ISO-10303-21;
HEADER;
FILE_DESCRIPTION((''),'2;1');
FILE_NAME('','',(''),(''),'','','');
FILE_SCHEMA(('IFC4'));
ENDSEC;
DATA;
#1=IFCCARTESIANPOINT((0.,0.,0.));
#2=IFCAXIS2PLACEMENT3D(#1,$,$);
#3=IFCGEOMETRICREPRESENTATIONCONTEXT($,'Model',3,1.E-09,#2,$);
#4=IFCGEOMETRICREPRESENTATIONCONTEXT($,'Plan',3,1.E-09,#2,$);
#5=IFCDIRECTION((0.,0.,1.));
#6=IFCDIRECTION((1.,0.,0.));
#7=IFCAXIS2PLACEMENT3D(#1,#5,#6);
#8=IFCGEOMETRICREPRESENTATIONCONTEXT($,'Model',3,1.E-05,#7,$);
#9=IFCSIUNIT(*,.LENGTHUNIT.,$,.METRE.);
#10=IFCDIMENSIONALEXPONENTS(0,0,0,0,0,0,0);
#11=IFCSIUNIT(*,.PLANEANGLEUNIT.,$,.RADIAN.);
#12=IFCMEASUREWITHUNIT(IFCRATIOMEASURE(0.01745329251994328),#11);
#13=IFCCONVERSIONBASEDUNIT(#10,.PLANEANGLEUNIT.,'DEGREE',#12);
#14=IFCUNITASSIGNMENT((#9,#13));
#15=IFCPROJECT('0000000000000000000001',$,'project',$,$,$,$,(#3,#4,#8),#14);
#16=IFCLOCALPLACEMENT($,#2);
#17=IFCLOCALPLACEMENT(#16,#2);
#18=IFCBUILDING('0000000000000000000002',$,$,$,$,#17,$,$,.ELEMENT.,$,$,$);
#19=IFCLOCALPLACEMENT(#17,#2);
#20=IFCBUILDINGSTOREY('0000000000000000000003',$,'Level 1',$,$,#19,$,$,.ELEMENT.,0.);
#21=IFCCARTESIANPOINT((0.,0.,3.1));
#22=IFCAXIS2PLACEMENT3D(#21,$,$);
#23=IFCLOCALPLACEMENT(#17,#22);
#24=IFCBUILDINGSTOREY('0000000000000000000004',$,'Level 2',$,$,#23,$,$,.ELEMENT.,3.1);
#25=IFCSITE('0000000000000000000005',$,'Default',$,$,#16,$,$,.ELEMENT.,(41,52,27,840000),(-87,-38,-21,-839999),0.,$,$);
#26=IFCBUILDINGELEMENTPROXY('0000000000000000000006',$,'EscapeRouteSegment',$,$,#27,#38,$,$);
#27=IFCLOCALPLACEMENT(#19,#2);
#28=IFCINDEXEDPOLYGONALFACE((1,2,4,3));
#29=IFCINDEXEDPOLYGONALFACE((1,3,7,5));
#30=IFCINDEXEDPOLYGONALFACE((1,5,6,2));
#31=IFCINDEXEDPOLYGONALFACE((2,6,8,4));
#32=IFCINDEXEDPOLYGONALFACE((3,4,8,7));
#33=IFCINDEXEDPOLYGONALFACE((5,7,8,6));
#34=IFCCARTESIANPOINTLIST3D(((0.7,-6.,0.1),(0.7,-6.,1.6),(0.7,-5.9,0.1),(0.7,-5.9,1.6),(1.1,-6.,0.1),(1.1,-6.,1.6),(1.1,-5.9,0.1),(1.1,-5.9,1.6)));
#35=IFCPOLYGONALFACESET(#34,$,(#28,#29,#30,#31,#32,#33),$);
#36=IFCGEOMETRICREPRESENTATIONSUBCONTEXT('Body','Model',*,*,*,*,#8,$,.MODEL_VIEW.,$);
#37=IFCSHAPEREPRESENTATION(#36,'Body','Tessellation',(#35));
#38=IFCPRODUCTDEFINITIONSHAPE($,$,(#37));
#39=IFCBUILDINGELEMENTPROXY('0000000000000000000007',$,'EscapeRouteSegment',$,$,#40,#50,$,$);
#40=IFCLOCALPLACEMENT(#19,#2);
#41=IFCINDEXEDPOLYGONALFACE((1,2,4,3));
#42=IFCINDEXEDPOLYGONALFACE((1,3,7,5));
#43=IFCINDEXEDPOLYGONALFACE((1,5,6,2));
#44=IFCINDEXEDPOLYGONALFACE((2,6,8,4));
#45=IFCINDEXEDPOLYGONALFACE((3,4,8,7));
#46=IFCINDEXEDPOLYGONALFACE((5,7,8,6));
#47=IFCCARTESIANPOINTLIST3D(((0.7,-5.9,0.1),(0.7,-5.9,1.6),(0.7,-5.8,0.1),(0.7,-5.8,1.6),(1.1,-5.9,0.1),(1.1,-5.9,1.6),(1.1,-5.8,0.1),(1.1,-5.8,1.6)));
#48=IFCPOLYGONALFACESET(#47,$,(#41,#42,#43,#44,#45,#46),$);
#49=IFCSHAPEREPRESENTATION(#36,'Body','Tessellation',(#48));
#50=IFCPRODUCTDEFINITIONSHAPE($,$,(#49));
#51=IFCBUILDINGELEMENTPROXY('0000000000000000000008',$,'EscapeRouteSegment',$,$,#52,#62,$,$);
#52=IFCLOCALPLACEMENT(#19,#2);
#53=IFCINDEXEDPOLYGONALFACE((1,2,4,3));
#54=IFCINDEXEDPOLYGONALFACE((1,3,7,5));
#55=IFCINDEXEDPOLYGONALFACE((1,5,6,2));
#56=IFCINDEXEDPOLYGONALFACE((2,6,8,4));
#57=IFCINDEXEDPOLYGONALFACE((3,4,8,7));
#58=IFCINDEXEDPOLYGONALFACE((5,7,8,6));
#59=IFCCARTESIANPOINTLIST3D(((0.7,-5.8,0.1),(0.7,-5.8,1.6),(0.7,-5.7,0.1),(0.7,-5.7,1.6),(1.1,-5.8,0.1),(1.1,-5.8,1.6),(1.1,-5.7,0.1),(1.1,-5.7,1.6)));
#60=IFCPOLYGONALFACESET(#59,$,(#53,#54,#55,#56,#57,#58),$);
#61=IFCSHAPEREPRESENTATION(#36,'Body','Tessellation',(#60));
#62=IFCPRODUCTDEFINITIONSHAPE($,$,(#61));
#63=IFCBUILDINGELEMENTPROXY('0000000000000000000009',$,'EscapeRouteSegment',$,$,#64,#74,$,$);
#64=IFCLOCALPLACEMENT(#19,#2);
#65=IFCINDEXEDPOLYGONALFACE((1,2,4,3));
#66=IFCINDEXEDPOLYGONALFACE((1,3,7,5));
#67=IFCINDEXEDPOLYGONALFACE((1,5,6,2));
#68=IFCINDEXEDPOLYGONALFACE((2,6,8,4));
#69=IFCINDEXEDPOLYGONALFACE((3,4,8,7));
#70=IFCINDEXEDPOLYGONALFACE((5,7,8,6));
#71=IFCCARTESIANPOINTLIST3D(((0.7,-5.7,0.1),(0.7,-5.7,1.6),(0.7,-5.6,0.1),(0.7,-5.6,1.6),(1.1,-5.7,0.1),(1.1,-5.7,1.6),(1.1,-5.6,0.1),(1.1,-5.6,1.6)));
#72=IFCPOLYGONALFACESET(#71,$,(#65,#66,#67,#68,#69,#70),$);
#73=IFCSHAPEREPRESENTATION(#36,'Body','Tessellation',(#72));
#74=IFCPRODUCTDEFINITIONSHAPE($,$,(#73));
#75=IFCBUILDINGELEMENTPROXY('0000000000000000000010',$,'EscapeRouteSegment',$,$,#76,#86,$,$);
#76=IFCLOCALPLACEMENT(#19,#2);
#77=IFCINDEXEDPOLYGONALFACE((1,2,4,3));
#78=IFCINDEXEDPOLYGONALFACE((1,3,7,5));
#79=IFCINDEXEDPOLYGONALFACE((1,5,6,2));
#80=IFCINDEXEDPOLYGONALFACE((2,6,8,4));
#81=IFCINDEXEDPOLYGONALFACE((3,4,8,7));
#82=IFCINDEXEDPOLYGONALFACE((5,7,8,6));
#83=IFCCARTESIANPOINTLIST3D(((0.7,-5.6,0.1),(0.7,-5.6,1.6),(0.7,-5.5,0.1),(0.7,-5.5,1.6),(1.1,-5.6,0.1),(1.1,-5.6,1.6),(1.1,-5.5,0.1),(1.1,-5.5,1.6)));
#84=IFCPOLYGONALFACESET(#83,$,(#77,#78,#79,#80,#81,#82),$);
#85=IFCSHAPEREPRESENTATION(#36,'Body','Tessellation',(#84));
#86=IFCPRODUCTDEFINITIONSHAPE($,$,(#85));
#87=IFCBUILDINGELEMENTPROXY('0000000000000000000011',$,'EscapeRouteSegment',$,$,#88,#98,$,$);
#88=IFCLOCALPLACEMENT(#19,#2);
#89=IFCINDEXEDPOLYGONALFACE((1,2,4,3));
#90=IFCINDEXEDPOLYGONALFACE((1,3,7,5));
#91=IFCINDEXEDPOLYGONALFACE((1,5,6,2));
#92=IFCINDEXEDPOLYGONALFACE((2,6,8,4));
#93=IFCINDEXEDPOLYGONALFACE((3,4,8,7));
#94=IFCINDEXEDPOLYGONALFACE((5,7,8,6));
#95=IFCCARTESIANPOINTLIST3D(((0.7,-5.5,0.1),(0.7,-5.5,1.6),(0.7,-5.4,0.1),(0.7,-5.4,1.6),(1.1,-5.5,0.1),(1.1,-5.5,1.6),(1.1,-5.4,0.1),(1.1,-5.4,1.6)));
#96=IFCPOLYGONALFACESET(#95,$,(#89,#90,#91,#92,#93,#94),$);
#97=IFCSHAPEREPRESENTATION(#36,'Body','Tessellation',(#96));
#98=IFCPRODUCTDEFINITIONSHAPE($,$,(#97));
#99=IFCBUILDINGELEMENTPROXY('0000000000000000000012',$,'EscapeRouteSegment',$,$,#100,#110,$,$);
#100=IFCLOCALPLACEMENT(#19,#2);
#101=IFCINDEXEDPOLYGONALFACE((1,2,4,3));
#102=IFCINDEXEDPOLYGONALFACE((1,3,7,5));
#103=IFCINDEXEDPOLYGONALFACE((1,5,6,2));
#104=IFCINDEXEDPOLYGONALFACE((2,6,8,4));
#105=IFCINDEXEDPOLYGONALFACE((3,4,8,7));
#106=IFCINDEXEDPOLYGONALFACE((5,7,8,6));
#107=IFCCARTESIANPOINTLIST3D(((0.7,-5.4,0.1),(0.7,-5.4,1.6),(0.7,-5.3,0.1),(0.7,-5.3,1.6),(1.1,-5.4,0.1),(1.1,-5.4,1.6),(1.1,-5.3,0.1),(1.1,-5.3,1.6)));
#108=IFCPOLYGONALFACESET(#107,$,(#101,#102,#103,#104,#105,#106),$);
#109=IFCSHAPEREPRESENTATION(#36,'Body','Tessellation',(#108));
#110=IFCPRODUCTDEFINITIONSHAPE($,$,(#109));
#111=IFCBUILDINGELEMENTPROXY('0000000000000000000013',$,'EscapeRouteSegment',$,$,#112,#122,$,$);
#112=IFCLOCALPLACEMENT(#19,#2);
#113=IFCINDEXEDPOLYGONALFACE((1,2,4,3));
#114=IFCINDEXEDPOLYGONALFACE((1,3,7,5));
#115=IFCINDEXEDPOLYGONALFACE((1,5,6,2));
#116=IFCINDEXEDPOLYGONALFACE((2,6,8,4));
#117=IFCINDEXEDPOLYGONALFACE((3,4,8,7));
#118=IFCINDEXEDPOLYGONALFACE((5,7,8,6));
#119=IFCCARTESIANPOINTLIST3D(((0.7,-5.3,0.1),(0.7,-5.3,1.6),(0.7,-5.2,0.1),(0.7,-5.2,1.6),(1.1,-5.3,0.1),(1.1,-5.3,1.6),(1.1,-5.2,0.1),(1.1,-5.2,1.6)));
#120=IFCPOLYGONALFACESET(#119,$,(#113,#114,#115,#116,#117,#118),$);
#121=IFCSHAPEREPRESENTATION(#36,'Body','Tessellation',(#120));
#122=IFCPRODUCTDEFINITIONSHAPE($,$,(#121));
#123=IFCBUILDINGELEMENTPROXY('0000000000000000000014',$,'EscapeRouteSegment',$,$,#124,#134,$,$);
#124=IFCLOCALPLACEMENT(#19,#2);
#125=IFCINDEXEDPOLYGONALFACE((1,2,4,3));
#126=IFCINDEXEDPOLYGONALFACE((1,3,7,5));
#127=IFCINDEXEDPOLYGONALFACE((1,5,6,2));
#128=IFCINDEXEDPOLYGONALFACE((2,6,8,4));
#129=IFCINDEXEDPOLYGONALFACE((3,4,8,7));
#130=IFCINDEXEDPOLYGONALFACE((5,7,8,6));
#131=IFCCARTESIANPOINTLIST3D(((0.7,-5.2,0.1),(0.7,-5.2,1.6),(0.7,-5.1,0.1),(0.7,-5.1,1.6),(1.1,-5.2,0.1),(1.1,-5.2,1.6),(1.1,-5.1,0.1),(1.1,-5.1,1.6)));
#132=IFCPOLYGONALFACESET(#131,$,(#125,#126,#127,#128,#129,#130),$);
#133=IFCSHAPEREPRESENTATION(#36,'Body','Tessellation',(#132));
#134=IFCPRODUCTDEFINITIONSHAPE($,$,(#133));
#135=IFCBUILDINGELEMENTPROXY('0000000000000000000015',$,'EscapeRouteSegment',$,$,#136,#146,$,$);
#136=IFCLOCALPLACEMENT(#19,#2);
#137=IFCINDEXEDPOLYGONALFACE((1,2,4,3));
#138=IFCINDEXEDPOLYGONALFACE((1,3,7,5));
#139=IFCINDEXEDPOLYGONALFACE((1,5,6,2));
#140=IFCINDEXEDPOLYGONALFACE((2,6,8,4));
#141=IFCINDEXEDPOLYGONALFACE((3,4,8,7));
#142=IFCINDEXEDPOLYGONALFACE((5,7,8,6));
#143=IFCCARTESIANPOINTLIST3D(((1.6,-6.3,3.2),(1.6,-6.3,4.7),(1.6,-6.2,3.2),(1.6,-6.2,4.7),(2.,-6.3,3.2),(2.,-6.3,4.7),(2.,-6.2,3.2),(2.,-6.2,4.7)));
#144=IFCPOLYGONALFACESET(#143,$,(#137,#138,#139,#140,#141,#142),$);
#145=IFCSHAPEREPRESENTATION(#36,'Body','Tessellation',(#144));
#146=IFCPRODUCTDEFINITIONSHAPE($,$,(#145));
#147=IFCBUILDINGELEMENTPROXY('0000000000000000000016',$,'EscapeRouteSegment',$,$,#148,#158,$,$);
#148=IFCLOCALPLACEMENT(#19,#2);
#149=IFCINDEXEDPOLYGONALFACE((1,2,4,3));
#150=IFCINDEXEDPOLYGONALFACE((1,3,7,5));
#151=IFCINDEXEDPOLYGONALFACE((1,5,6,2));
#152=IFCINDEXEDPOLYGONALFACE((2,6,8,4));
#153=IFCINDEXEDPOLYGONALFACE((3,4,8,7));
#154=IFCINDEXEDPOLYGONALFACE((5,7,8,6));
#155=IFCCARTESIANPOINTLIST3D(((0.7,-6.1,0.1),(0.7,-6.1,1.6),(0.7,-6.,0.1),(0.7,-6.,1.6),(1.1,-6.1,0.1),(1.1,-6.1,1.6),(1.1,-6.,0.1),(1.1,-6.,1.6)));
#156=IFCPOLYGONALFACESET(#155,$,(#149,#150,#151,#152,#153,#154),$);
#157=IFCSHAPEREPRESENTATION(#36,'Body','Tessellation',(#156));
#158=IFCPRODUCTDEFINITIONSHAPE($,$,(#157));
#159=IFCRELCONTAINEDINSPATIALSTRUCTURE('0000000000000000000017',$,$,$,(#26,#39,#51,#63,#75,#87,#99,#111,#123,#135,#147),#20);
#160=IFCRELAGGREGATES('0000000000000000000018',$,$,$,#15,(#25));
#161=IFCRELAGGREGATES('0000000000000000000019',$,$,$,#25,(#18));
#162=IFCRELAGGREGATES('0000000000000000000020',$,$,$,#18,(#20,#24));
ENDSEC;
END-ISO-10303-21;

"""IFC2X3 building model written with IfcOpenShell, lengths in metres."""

from ifc_helpers import new_model, entity, si_unit, converted_unit, frame, origin, origin_with_axes, place, context, subcontext, project, spatial, polyline, outline, extrude, element, save


model = new_model("IFC2X3")

# Units and contexts
model_context_1 = context("Model", 3, precision=1e-09, world=origin())
plan_context = context("Plan", 3, precision=1e-09, world=origin())
model_context_2 = context("Model", 3, precision=1e-05, world=origin_with_axes())
body_context = subcontext(model_context_2, "Body", "Model", "MODEL_VIEW")
ifc_project = project(units=[si_unit("LENGTHUNIT", "METRE"), converted_unit("PLANEANGLEUNIT", "DEGREE", entity("IfcRatioMeasure", 0.01745329251994328), si_unit("PLANEANGLEUNIT", "RADIAN"), dimensions=[0, 0, 0, 0, 0, 0, 0])], contexts=[model_context_1, plan_context, model_context_2])

# Site, building, storey
site_placement = place(None, origin())
site = spatial("IfcSite", under=ifc_project, at=site_placement, Name="Default", CompositionType="ELEMENT", RefLatitude=(41, 52, 27, 840000), RefLongitude=(-87, -38, -21, -839999), RefElevation=0.0)
building_placement = place(site_placement, origin())
building = spatial("IfcBuilding", under=site, at=building_placement, CompositionType="ELEMENT")
storey_1_placement = place(building_placement, origin())
storey_1 = spatial("IfcBuildingStorey", under=building, at=storey_1_placement, Name="Level 1", CompositionType="ELEMENT", Elevation=0.0)

# Shared definitions
storey_2_placement = place(building_placement, frame((0.0, 0.0, 3.1)))
storey_2 = spatial("IfcBuildingStorey", under=building, at=storey_2_placement, Name="Level 2", CompositionType="ELEMENT", Elevation=3.1)

# Building element proxies
for number, where, z_axis, x_axis, name in (
    (1, (0.9, -6.0, 0.1), (0.0, 0.0, 1.0), (0.0, 1.0, 0.0), "EscapeRouteSegment"),
    (2, (0.9, -5.9, 0.1), (0.0, 0.0, 1.0), (0.0, 1.0, 0.0), "EscapeRouteSegment"),
):
    element("IfcBuildingElementProxy", number, at=place(storey_1_placement, frame(where, z_axis=z_axis, x_axis=x_axis)), inside=storey_1, Name=name, context=body_context, shape_type="SweptSolid", body=[
        extrude(outline(polyline([(0.0, -0.2), (0.0, 0.2), (0.1, 0.2), (0.1, -0.2), (0.0, -0.2)])), origin_with_axes(), (0.0, 0.0, 1.0), 1.5),
    ])
proxy_1_placement = place(storey_1_placement, frame((0.9, -5.8, 0.1), z_axis=(0.0, 0.0, 1.0), x_axis=(0.0, 1.0, 0.0)))
element("IfcBuildingElementProxy", 3, at=proxy_1_placement, inside=storey_1, Name="EscapeRouteSegment", context=body_context, shape_type="SweptSolid", body=[
    extrude(outline(polyline([(0.0, -0.2), (0.0, 0.2), (0.1, 0.2), (0.1, -0.2), (0.0, -0.2)])), origin_with_axes(), (0.0, 0.0, 1.0), 1.5),
])
for number, where, z_axis, x_axis, name in (
    (4, (0.9, -5.7, 0.1), (0.0, 0.0, 1.0), (0.0, 1.0, 0.0), "EscapeRouteSegment"),
    (5, (0.9, -5.6, 0.1), (0.0, 0.0, 1.0), (0.0, 1.0, 0.0), "EscapeRouteSegment"),
    (6, (0.9, -5.5, 0.1), (0.0, 0.0, 1.0), (0.0, 1.0, 0.0), "EscapeRouteSegment"),
    (7, (0.9, -5.4, 0.1), (0.0, 0.0, 1.0), (0.0, 1.0, 0.0), "EscapeRouteSegment"),
):
    element("IfcBuildingElementProxy", number, at=place(storey_1_placement, frame(where, z_axis=z_axis, x_axis=x_axis)), inside=storey_1, Name=name, context=body_context, shape_type="SweptSolid", body=[
        extrude(outline(polyline([(0.0, -0.2), (0.0, 0.2), (0.1, 0.2), (0.1, -0.2), (0.0, -0.2)])), origin_with_axes(), (0.0, 0.0, 1.0), 1.5),
    ])
proxy_2_placement = place(storey_1_placement, frame((0.9, -5.3, 0.1), z_axis=(0.0, 0.0, 1.0), x_axis=(0.0, 1.0, 0.0)))
element("IfcBuildingElementProxy", 8, at=proxy_2_placement, inside=storey_1, Name="EscapeRouteSegment", context=body_context, shape_type="SweptSolid", body=[
    extrude(outline(polyline([(0.0, -0.2), (0.0, 0.2), (0.1, 0.2), (0.1, -0.2), (0.0, -0.2)])), origin_with_axes(), (0.0, 0.0, 1.0), 1.5),
])
for number, where, z_axis, x_axis, name in (
    (9, (0.9, -5.2, 0.1), (0.0, 0.0, 1.0), (0.0, 1.0, 0.0), "EscapeRouteSegment"),
):
    element("IfcBuildingElementProxy", number, at=place(storey_1_placement, frame(where, z_axis=z_axis, x_axis=x_axis)), inside=storey_1, Name=name, context=body_context, shape_type="SweptSolid", body=[
        extrude(outline(polyline([(0.0, -0.2), (0.0, 0.2), (0.1, 0.2), (0.1, -0.2), (0.0, -0.2)])), origin_with_axes(), (0.0, 0.0, 1.0), 1.5),
    ])
proxy_3_placement = place(storey_1_placement, frame((1.8, -6.2, 3.2), z_axis=(0.0, 0.0, 1.0), x_axis=(0.0, -1.0, 0.0)))
element("IfcBuildingElementProxy", 10, at=proxy_3_placement, inside=storey_1, Name="EscapeRouteSegment", context=body_context, shape_type="SweptSolid", body=[
    extrude(outline(polyline([(0.0, -0.2), (0.0, 0.2), (0.1, 0.2), (0.1, -0.2), (0.0, -0.2)])), origin_with_axes(), (0.0, 0.0, 1.0), 1.5),
])
for number, where, z_axis, x_axis, name in (
    (11, (0.9, -6.1, 0.1), (0.0, 0.0, 1.0), (0.0, 1.0, 0.0), "EscapeRouteSegment"),
):
    element("IfcBuildingElementProxy", number, at=place(storey_1_placement, frame(where, z_axis=z_axis, x_axis=x_axis)), inside=storey_1, Name=name, context=body_context, shape_type="SweptSolid", body=[
        extrude(outline(polyline([(0.0, -0.2), (0.0, 0.2), (0.1, 0.2), (0.1, -0.2), (0.0, -0.2)])), origin_with_axes(), (0.0, 0.0, 1.0), 1.5),
    ])

save(model, "model.ifc")
